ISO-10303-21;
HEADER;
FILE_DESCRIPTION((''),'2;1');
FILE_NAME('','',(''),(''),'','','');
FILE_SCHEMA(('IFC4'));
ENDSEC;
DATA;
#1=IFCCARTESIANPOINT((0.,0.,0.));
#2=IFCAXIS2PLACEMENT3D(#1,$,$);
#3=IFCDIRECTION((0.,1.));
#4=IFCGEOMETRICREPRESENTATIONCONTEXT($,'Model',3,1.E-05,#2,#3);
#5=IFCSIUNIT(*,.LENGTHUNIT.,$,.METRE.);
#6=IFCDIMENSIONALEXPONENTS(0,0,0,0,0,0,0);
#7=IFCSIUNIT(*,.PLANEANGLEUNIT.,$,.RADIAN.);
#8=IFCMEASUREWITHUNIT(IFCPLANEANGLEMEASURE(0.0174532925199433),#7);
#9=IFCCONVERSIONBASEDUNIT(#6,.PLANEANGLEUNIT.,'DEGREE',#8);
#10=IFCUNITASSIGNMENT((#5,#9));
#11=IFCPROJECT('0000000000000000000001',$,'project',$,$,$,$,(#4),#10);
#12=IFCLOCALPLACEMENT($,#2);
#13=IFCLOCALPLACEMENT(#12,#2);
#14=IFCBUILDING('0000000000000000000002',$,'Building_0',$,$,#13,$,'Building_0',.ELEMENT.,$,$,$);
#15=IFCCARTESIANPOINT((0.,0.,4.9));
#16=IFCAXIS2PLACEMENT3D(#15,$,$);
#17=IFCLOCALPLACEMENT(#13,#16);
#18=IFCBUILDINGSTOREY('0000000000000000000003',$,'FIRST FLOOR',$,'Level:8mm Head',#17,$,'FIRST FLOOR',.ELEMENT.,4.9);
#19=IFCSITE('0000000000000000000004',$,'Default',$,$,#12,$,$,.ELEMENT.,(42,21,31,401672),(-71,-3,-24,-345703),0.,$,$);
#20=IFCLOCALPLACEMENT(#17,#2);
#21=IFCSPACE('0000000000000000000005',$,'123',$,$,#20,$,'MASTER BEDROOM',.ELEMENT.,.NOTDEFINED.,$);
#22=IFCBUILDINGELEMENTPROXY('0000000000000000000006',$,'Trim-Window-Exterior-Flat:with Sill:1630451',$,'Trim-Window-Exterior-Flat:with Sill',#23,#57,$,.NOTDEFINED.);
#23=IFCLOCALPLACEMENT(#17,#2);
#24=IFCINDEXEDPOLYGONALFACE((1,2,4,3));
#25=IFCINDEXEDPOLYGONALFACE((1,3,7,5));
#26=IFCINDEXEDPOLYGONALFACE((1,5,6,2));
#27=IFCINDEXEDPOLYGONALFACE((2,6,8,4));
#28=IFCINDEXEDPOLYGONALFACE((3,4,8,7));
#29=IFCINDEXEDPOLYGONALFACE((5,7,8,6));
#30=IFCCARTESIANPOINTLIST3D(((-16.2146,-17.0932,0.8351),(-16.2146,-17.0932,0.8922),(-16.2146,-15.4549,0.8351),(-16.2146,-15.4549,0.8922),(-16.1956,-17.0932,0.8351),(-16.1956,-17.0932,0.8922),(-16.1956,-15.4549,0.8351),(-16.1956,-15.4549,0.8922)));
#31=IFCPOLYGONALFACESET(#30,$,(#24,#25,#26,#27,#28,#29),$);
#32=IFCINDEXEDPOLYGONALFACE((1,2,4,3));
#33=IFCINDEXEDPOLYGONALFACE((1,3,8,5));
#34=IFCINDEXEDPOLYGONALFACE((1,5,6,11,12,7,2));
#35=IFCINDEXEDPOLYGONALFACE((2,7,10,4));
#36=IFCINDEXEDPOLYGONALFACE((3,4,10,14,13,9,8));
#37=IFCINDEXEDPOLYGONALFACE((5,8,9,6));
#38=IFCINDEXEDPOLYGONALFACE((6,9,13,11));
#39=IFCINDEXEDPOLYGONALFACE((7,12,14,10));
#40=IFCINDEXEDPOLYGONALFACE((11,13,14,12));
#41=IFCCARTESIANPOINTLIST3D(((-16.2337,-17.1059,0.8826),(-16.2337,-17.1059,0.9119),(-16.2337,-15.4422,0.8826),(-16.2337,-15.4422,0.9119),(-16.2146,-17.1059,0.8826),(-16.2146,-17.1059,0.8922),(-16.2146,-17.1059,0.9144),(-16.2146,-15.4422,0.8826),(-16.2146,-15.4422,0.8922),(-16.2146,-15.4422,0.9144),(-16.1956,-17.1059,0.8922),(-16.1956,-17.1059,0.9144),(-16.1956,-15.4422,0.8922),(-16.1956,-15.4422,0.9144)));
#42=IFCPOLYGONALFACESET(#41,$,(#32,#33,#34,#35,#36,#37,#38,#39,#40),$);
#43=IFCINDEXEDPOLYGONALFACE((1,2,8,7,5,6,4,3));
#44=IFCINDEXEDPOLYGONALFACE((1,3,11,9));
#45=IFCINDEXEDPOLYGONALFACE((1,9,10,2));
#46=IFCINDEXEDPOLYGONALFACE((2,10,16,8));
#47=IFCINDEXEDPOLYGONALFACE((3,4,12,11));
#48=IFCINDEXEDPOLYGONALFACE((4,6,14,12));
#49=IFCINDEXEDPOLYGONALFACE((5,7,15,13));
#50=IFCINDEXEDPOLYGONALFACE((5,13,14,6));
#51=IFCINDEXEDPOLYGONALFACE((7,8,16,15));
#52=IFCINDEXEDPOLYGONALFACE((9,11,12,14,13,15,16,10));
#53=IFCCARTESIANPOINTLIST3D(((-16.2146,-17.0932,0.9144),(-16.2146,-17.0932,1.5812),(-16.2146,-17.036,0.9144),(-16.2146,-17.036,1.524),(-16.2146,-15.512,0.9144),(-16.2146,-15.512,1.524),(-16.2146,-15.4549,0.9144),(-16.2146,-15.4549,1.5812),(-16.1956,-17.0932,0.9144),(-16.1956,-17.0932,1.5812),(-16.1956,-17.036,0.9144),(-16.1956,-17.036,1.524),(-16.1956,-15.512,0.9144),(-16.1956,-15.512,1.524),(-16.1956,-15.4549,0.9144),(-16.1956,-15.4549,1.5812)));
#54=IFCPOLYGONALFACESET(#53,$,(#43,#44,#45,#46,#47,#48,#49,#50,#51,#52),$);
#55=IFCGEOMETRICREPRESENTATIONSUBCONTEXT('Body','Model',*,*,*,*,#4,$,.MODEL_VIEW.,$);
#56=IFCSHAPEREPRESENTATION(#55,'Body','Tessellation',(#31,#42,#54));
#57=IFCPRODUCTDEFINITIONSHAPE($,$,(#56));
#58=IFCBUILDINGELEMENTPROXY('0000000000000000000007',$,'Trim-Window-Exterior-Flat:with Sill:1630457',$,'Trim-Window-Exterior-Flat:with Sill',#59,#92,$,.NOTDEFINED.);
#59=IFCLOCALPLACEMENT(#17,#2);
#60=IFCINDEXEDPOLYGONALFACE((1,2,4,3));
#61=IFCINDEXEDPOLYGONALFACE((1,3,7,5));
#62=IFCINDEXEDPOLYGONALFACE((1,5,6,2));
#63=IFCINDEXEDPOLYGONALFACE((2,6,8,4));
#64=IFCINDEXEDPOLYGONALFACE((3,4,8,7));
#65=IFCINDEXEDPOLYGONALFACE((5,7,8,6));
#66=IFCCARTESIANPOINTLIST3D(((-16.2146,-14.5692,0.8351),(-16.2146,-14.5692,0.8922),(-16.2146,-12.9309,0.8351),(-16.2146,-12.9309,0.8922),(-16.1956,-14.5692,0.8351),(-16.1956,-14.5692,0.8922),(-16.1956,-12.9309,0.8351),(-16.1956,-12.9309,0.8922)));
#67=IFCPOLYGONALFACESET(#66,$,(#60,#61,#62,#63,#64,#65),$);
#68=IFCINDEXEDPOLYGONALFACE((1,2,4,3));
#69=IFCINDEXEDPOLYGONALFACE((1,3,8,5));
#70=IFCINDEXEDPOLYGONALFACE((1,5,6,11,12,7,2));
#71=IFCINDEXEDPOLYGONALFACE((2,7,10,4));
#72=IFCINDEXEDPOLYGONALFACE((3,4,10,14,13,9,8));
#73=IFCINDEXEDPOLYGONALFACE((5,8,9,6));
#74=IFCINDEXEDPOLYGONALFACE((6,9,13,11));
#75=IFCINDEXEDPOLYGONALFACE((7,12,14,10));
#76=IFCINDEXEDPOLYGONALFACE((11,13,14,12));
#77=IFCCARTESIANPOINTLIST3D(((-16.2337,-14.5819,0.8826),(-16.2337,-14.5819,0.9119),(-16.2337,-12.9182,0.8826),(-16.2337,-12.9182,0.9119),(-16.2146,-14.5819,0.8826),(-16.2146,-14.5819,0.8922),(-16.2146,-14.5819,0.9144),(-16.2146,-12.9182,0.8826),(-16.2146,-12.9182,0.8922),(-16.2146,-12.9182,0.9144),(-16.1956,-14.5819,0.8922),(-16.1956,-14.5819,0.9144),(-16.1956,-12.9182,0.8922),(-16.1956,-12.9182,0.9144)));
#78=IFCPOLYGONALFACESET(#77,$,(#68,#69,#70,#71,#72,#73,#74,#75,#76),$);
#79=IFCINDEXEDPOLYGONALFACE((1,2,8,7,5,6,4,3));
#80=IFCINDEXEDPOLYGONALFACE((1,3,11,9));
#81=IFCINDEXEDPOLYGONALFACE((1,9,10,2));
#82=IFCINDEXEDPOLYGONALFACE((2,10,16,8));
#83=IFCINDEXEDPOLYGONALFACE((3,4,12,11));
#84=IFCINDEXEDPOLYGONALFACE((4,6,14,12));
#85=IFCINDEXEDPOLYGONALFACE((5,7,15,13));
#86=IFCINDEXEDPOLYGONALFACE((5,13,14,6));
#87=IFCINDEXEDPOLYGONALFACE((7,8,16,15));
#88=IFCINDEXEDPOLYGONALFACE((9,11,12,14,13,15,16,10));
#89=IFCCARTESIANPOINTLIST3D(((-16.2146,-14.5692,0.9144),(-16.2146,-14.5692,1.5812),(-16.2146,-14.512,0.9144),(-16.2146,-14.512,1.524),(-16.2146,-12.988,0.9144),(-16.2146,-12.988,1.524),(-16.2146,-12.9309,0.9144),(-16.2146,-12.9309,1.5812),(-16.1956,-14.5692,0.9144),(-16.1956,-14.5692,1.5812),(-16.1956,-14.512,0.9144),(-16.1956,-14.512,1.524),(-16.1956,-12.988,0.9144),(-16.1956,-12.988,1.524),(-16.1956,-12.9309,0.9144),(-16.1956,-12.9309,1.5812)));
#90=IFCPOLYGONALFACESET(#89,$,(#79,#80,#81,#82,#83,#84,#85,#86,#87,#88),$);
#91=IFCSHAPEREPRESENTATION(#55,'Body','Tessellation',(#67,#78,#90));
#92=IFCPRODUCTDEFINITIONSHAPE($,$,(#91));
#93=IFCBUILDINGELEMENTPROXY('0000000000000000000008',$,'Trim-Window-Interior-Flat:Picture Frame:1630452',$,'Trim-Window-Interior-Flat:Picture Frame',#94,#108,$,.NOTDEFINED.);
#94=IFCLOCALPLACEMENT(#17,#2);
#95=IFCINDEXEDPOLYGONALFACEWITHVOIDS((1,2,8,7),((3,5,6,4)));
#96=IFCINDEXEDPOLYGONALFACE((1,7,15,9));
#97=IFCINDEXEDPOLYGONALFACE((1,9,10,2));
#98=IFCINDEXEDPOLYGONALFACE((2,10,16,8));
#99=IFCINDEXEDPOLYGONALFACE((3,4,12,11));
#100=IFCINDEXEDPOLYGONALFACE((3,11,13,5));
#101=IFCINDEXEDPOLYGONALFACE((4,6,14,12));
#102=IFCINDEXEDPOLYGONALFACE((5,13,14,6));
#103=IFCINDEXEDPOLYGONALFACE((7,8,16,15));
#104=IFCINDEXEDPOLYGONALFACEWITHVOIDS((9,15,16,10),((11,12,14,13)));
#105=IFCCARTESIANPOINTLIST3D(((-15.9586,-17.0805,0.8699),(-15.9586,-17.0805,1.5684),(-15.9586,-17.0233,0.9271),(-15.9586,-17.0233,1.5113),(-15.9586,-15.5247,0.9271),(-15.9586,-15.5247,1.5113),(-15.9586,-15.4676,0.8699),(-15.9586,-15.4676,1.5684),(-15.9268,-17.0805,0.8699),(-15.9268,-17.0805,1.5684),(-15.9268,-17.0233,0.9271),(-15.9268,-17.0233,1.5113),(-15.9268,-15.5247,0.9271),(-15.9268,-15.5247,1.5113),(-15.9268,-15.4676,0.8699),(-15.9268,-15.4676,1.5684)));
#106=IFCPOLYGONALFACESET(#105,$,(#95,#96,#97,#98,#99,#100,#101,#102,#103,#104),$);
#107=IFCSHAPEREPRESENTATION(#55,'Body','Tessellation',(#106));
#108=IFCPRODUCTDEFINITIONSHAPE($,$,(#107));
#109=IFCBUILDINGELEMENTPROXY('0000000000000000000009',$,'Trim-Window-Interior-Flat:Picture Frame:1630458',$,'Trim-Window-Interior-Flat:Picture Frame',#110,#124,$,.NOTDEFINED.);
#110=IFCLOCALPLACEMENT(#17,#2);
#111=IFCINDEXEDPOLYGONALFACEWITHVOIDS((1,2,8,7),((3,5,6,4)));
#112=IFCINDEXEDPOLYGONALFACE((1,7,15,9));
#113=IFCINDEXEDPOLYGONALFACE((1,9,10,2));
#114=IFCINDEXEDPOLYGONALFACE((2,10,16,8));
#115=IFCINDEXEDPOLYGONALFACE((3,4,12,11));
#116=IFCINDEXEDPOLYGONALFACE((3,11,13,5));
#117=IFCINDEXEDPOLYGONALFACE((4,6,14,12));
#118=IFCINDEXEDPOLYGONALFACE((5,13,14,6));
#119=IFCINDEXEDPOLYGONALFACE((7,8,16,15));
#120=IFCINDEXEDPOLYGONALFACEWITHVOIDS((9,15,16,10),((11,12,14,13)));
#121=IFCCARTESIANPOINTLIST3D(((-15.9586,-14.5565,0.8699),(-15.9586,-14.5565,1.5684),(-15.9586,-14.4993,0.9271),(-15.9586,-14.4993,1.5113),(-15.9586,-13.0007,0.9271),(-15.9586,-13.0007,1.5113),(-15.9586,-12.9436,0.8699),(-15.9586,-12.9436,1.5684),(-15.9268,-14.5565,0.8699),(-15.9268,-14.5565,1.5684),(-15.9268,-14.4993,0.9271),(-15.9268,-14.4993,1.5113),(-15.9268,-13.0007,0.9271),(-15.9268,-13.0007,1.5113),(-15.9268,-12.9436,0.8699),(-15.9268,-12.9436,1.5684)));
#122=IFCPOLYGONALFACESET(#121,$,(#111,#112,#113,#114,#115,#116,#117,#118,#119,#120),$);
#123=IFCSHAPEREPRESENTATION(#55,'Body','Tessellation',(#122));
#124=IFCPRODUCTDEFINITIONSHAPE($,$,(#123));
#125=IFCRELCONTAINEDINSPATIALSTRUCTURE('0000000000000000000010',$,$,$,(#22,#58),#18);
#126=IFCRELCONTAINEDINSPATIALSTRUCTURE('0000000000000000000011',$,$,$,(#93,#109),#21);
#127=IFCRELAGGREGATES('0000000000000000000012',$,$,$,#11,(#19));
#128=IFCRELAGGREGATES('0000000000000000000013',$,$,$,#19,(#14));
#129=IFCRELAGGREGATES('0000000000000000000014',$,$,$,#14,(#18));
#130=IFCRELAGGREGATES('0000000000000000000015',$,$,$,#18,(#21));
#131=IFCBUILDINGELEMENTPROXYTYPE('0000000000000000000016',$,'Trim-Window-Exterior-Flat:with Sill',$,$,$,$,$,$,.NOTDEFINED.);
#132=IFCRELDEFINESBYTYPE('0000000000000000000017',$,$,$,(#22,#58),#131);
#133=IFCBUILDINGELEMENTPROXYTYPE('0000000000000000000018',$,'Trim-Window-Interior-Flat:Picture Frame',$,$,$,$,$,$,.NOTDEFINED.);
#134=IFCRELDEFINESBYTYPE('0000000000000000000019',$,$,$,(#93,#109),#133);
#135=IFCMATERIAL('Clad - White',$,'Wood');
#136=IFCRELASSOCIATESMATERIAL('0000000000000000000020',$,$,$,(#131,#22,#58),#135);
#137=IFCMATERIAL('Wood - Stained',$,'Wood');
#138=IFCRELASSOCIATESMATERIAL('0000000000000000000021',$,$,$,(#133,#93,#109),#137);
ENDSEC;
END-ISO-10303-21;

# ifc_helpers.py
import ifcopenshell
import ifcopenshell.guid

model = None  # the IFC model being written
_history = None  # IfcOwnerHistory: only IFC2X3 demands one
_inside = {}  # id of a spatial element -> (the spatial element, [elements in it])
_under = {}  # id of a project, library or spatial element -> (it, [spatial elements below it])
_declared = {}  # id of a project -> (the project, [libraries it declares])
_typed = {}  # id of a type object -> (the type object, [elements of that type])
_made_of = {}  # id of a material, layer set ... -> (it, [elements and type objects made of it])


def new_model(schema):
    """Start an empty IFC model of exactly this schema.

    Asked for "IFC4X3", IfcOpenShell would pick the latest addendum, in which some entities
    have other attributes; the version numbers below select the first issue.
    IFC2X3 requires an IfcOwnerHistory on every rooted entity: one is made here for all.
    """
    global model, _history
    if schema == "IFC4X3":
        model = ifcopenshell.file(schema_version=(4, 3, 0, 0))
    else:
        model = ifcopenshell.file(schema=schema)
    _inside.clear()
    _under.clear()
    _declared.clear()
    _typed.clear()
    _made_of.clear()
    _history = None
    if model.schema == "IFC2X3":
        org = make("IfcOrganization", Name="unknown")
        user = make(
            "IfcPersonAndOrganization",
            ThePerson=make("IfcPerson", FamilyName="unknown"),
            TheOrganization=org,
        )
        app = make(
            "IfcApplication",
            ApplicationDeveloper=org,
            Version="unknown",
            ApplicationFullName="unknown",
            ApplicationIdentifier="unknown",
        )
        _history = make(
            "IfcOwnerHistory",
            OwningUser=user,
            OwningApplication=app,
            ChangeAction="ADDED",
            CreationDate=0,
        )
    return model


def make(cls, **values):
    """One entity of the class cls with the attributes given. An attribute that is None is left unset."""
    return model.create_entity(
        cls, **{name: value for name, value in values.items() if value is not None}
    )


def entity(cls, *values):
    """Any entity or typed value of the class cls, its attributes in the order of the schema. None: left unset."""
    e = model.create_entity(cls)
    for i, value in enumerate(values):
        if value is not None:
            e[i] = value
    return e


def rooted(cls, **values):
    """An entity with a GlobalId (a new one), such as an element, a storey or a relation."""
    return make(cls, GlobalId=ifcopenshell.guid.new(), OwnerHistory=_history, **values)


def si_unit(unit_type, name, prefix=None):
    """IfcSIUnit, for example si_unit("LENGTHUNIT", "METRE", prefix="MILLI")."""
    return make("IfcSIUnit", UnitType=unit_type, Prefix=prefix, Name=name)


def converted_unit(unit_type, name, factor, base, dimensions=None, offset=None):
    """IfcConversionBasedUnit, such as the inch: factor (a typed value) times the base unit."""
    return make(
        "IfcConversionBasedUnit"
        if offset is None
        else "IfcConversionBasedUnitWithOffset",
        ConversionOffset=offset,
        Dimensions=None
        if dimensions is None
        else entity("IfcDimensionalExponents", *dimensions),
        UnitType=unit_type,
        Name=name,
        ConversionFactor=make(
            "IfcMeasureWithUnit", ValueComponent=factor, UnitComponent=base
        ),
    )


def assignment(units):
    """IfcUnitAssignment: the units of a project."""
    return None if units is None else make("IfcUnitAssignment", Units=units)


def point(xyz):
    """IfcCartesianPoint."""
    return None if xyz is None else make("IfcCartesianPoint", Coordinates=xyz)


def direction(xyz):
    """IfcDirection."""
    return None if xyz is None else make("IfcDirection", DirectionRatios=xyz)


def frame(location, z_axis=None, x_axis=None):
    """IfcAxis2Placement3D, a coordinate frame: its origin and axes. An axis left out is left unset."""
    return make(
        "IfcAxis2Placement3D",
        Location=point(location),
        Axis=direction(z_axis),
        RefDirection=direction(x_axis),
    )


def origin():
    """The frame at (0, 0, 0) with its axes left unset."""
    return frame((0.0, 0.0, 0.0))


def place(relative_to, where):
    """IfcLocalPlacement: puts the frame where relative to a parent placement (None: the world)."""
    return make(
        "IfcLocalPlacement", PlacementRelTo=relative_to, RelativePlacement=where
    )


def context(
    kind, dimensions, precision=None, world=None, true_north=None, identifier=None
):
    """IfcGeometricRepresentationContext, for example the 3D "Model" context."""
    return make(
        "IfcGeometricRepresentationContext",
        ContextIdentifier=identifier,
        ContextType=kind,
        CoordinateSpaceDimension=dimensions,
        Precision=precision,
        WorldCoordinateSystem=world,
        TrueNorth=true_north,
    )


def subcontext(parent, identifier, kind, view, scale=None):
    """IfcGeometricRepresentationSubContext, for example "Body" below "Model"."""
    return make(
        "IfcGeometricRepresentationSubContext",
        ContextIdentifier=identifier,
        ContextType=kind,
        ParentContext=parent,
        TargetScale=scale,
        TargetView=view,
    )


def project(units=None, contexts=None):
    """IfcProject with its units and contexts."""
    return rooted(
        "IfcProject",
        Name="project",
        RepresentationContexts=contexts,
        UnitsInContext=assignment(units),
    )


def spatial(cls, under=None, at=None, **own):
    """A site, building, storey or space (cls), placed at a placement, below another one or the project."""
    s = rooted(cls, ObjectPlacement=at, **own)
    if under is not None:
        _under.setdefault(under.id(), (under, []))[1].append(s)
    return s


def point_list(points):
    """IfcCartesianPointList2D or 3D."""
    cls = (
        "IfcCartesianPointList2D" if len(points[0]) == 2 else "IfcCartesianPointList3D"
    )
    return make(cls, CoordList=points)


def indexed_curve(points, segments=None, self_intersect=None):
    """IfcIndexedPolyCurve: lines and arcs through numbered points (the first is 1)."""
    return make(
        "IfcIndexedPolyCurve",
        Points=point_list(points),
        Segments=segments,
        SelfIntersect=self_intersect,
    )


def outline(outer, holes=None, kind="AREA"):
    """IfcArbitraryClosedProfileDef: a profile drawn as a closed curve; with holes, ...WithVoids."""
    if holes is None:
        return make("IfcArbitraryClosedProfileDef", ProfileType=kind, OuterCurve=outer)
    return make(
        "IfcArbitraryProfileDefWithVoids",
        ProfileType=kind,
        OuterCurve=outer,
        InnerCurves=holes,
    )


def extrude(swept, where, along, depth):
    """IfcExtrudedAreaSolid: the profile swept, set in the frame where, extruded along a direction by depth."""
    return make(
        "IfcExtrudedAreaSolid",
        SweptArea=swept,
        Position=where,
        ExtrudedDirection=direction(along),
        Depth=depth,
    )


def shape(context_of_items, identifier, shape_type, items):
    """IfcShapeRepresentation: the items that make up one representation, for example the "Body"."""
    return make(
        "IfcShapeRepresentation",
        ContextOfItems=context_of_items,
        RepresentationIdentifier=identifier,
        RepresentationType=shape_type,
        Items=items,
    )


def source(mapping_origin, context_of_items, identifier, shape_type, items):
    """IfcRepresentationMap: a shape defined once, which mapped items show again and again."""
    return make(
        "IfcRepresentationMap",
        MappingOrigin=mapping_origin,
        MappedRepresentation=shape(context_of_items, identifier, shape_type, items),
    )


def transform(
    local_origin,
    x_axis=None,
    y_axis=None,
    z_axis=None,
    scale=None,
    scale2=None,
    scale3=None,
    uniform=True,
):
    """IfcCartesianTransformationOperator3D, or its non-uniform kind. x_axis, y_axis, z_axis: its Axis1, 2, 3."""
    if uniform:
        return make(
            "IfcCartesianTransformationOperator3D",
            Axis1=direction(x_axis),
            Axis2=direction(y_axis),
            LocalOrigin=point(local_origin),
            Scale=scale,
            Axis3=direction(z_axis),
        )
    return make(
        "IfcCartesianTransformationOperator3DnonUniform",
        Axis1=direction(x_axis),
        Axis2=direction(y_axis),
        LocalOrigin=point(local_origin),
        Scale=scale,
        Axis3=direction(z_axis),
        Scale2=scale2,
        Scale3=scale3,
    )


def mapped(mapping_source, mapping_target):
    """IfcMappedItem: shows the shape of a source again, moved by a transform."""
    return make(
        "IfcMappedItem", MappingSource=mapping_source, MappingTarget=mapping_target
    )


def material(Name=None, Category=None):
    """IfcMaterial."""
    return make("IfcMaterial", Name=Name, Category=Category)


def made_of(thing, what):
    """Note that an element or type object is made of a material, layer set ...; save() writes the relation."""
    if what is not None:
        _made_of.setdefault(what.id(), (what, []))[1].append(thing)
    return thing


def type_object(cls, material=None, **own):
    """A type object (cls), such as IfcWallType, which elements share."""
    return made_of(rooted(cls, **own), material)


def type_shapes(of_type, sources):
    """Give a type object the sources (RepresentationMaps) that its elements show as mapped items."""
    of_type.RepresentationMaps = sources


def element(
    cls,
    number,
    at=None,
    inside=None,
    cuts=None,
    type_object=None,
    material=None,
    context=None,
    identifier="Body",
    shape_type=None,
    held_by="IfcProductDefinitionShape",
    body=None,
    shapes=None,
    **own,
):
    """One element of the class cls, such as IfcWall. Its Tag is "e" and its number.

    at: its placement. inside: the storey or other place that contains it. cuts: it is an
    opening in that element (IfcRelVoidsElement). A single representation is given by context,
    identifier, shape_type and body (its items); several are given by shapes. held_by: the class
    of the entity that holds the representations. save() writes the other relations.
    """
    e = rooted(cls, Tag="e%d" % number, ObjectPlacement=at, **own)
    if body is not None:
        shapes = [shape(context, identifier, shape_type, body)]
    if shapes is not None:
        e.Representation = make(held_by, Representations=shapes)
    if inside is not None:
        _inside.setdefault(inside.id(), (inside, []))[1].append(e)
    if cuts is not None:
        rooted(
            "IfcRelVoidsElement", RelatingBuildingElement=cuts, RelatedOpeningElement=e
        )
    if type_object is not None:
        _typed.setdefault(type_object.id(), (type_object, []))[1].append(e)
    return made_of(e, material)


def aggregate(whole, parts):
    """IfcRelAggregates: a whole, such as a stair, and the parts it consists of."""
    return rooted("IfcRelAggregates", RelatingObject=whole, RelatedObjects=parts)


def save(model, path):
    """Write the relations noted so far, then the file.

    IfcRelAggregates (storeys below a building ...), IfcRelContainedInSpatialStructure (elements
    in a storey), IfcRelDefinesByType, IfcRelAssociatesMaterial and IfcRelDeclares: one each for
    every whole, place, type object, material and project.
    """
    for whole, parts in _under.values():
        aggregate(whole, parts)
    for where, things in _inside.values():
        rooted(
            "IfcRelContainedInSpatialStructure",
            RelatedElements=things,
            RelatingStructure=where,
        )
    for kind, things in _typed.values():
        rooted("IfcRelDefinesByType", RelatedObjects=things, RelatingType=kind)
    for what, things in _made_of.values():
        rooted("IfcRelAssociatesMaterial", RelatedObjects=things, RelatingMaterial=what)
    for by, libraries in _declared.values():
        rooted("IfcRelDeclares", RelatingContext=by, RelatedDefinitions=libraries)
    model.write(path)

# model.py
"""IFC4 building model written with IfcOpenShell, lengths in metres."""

from ifc_helpers import new_model, entity, si_unit, converted_unit, direction, frame, origin, place, context, subcontext, project, spatial, indexed_curve, outline, extrude, source, transform, mapped, material, type_object, type_shapes, element, save


model = new_model("IFC4")

# Units and contexts
model_context = context("Model", 3, precision=1e-05, world=origin(), true_north=direction((0.0, 1.0)))
body_context = subcontext(model_context, "Body", "Model", "MODEL_VIEW")
ifc_project = project(units=[si_unit("LENGTHUNIT", "METRE"), converted_unit("PLANEANGLEUNIT", "DEGREE", entity("IfcPlaneAngleMeasure", 0.0174532925199433), si_unit("PLANEANGLEUNIT", "RADIAN"), dimensions=[0, 0, 0, 0, 0, 0, 0])], contexts=[model_context])

# Site, building, storey
site_placement = place(None, origin())
site = spatial("IfcSite", under=ifc_project, at=site_placement, Name="Default", CompositionType="ELEMENT", RefLatitude=(42, 21, 31, 401672), RefLongitude=(-71, -3, -24, -345703), RefElevation=0.0)
building_placement = place(site_placement, origin())
building = spatial("IfcBuilding", under=site, at=building_placement, Name="Building_0", LongName="Building_0", CompositionType="ELEMENT")
storey_placement = place(building_placement, frame((0.0, 0.0, 4.9)))
storey = spatial("IfcBuildingStorey", under=building, at=storey_placement, Name="FIRST FLOOR", ObjectType="Level:8mm Head", LongName="FIRST FLOOR", CompositionType="ELEMENT", Elevation=4.9)

# Shared definitions
ifc_material_1 = material(Name="Clad - White", Category="Wood")

# Shared definitions
space_placement = place(storey_placement, origin())
space = spatial("IfcSpace", under=storey, at=space_placement, Name="123", LongName="MASTER BEDROOM", CompositionType="ELEMENT", PredefinedType="NOTDEFINED")

# Building element proxies
ifc_material_2 = material(Name="Wood - Stained", Category="Wood")
building_element_proxy_type_1 = type_object("IfcBuildingElementProxyType", Name="Trim-Window-Exterior-Flat:with Sill", PredefinedType="NOTDEFINED", material=ifc_material_1)
shared_shape_1 = source(origin(), body_context, "Body", "SweptSolid", [
    extrude(outline(indexed_curve([(-0.8191, -0.0286), (0.8191, -0.0286), (0.8191, 0.0286), (-0.8191, 0.0286), (-0.8191, -0.0286)], self_intersect=False)), frame((0.0, -0.6604, 0.0), z_axis=(0.0, 0.0, 1.0), x_axis=(-1.0, 0.0, 0.0)), (0.0, 0.0, 1.0), 0.0191),
    extrude(outline(indexed_curve([(-0.019, -0.016), (0.0, -0.016), (0.0, -0.0064), (0.019, -0.0064), (0.019, 0.0158), (0.0, 0.0158), (-0.019, 0.0133), (-0.019, -0.016)], self_intersect=False)), frame((-0.8318, -0.6254, 0.019), z_axis=(1.0, 0.0, 0.0), x_axis=(0.0, 0.0, -1.0)), (0.0, 0.0, 1.0), 1.6637),
    extrude(outline(indexed_curve([(-0.3477, -0.8192), (0.3191, -0.8192), (0.3191, -0.762), (-0.2905, -0.762), (-0.2905, 0.762), (0.3191, 0.762), (0.3191, 0.8191), (-0.3477, 0.8191), (-0.3477, -0.8192)], self_intersect=False)), frame((0.0, -0.2905, 0.0), z_axis=(0.0, 0.0, 1.0), x_axis=(0.0, -1.0, 0.0)), (0.0, 0.0, 1.0), 0.0191),
])
type_shapes(building_element_proxy_type_1, [shared_shape_1])
for number, where, z_axis, x_axis, name in (
    (1, (-16.1956, -16.274, 1.524), (-1.0, 0.0, 0.0), (0.0, -1.0, 0.0), "Trim-Window-Exterior-Flat:with Sill:1630451"),
    (2, (-16.1956, -13.75, 1.524), (-1.0, 0.0, 0.0), (0.0, -1.0, 0.0), "Trim-Window-Exterior-Flat:with Sill:1630457"),
):
    element("IfcBuildingElementProxy", number, at=place(storey_placement, frame(where, z_axis=z_axis, x_axis=x_axis)), inside=storey, type_object=building_element_proxy_type_1, material=ifc_material_1, Name=name, ObjectType="Trim-Window-Exterior-Flat:with Sill", PredefinedType="NOTDEFINED", context=body_context, shape_type="MappedRepresentation", body=[
        mapped(shared_shape_1, transform((0.0, 0.0, 0.0), scale=1.0)),
    ])
building_element_proxy_type_2 = type_object("IfcBuildingElementProxyType", Name="Trim-Window-Interior-Flat:Picture Frame", PredefinedType="NOTDEFINED", material=ifc_material_2)
shared_shape_2 = source(origin(), body_context, "Body", "SweptSolid", [
    extrude(outline(indexed_curve([(-0.8064, -0.3492), (0.8064, -0.3492), (0.8064, 0.3492), (-0.8064, 0.3492), (-0.8064, -0.3492)], self_intersect=False), holes=[indexed_curve([(-0.7493, -0.2921), (-0.7493, 0.2921), (0.7493, 0.2921), (0.7493, -0.2921), (-0.7493, -0.2921)], self_intersect=False)]), frame((0.0, -0.3048, 0.0), z_axis=(0.0, 0.0, 1.0), x_axis=(-1.0, 0.0, 0.0)), (0.0, 0.0, 1.0), 0.0318),
])
type_shapes(building_element_proxy_type_2, [shared_shape_2])
for number, where, z_axis, x_axis, name in (
    (3, (-15.9586, -16.274, 1.524), (1.0, 0.0, 0.0), (0.0, 1.0, 0.0), "Trim-Window-Interior-Flat:Picture Frame:1630452"),
    (4, (-15.9586, -13.75, 1.524), (1.0, 0.0, 0.0), (0.0, 1.0, 0.0), "Trim-Window-Interior-Flat:Picture Frame:1630458"),
):
    element("IfcBuildingElementProxy", number, at=place(space_placement, frame(where, z_axis=z_axis, x_axis=x_axis)), inside=space, type_object=building_element_proxy_type_2, material=ifc_material_2, Name=name, ObjectType="Trim-Window-Interior-Flat:Picture Frame", PredefinedType="NOTDEFINED", context=body_context, shape_type="MappedRepresentation", body=[
        mapped(shared_shape_2, transform((0.0, 0.0, 0.0), scale=1.0)),
    ])

save(model, "model.ifc")
